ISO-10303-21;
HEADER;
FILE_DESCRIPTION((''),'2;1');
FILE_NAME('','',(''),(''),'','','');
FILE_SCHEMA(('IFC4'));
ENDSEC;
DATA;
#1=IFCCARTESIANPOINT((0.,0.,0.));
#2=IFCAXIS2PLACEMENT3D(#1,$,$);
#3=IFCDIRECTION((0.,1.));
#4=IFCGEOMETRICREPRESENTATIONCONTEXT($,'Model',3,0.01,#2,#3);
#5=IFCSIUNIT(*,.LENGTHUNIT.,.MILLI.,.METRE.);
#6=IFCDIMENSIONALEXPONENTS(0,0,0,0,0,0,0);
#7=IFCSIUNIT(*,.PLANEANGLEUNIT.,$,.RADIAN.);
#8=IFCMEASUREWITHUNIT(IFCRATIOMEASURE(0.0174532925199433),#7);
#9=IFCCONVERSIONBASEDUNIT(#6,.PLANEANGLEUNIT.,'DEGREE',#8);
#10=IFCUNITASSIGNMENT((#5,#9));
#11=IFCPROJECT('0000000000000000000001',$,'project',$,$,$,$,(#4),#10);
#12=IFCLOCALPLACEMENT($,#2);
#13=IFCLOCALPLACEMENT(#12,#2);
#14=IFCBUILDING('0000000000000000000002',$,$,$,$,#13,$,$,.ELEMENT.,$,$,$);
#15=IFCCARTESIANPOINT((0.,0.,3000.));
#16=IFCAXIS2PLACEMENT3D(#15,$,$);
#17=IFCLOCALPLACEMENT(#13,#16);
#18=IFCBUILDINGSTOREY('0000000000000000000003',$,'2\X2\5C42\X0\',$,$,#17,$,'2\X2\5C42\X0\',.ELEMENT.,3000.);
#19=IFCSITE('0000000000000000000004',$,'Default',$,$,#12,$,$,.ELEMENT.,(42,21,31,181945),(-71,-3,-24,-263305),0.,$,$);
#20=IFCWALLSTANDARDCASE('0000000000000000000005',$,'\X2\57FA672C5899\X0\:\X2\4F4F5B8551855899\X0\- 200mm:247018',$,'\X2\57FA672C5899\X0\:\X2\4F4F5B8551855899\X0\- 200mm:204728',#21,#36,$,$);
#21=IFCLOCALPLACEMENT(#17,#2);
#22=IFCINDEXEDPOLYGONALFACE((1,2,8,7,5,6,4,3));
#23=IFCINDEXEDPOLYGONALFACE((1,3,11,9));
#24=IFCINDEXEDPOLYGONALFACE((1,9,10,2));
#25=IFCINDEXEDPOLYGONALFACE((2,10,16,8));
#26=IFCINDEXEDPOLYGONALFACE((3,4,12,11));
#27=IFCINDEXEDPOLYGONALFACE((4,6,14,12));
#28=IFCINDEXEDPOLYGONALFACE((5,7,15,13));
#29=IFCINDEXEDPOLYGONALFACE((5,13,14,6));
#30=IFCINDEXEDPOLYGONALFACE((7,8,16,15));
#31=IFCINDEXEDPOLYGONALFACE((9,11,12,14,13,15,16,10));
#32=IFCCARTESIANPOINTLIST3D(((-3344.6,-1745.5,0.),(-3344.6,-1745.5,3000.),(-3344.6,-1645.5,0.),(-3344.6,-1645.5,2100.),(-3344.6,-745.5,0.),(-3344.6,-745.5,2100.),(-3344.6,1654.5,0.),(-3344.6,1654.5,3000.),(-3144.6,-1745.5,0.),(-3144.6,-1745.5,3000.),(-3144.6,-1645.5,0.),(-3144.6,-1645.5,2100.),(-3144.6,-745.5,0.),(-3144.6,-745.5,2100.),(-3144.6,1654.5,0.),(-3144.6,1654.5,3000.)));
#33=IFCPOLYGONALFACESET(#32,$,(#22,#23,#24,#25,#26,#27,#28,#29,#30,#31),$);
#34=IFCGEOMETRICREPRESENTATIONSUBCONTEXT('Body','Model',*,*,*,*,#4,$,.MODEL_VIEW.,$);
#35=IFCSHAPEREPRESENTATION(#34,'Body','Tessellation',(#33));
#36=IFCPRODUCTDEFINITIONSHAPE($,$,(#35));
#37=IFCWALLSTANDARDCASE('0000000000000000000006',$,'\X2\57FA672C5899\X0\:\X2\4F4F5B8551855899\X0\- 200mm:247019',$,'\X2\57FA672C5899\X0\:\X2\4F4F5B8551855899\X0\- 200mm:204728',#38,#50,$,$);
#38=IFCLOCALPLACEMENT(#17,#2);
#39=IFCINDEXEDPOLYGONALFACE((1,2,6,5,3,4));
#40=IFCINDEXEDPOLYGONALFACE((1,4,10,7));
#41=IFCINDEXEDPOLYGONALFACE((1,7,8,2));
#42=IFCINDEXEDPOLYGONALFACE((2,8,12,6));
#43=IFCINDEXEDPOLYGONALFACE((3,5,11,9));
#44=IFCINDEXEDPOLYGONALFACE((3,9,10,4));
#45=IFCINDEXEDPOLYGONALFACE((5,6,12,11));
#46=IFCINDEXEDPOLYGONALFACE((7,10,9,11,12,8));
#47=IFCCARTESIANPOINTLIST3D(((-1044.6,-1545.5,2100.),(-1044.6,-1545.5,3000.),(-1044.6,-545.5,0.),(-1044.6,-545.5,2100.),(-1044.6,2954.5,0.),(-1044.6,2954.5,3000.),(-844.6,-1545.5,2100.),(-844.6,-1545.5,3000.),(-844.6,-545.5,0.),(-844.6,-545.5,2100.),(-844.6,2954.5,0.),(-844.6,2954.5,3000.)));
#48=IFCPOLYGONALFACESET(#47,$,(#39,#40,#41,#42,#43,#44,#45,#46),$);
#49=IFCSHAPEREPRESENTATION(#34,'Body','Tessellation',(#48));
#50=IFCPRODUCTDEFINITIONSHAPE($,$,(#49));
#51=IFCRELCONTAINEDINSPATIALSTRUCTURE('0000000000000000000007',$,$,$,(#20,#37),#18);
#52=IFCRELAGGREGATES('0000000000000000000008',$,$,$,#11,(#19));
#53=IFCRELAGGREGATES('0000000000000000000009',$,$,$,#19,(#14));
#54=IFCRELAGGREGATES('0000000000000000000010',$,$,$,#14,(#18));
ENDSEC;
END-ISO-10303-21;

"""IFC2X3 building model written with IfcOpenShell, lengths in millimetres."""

from ifc_helpers import new_model, entity, si_unit, converted_unit, direction, frame, frame_2d, origin, place, context, subcontext, project, spatial, polyline, rectangle, extrude, clip, bounded_halfspace, element, save


model = new_model("IFC2X3")

# Units and contexts
model_context = context("Model", 3, precision=0.01, world=origin(), true_north=direction((0.0, 1.0)))
body_context = subcontext(model_context, "Body", "Model", "MODEL_VIEW")
ifc_project = project(units=[si_unit("LENGTHUNIT", "METRE", prefix="MILLI"), converted_unit("PLANEANGLEUNIT", "DEGREE", entity("IfcRatioMeasure", 0.0174532925199433), si_unit("PLANEANGLEUNIT", "RADIAN"), dimensions=[0, 0, 0, 0, 0, 0, 0])], contexts=[model_context])

# Site, building, storey
site_placement = place(None, origin())
site = spatial("IfcSite", under=ifc_project, at=site_placement, Name="Default", CompositionType="ELEMENT", RefLatitude=(42, 21, 31, 181945), RefLongitude=(-71, -3, -24, -263305), RefElevation=0.0)
building_placement = place(site_placement, origin())
building = spatial("IfcBuilding", under=site, at=building_placement, CompositionType="ELEMENT")
storey_placement = place(building_placement, frame((0.0, 0.0, 3000.0)))
storey = spatial("IfcBuildingStorey", under=building, at=storey_placement, Name="2层", LongName="2层", CompositionType="ELEMENT", Elevation=3000.0)

# Walls, openings
wall_1_placement = place(storey_placement, frame((-3244.6, -1745.5, 0.0), z_axis=(0.0, 0.0, 1.0), x_axis=(0.0, 1.0, 0.0)))
wall_1 = element("IfcWallStandardCase", 1, at=wall_1_placement, inside=storey, Name="基本墙:住宅内墙- 200mm:247018", ObjectType="基本墙:住宅内墙- 200mm:204728", context=body_context, shape_type="SweptSolid", body=[
    extrude(rectangle(XDim=3400.0, YDim=200.0, at=frame_2d((1700.0, 0.0), x_axis=(-1.0, 0.0))), origin(), (0.0, 0.0, 1.0), 3000.0),
])
opening_1_placement = place(wall_1_placement, frame((100.0, -100.0, 0.0)))
element("IfcOpeningElement", 2, at=opening_1_placement, cuts=wall_1, ObjectType="Opening", context=body_context, shape_type="SweptSolid", body=[
    extrude(rectangle(XDim=2100.0, YDim=900.0, at=frame_2d((1050.0, 450.0), x_axis=(1.0, 0.0))), frame((0.0, 0.0, 0.0), z_axis=(0.0, 1.0, 0.0), x_axis=(0.0, 0.0, 1.0)), (0.0, 0.0, 1.0), 200.0),
])
wall_2_placement = place(storey_placement, frame((-944.6, 2954.5, 0.0), z_axis=(0.0, 0.0, 1.0), x_axis=(0.0, -1.0, 0.0)))
wall_2 = element("IfcWallStandardCase", 3, at=wall_2_placement, inside=storey, Name="基本墙:住宅内墙- 200mm:247019", ObjectType="基本墙:住宅内墙- 200mm:204728", context=body_context, shape_type="Clipping", body=[
    clip(clip(extrude(rectangle(XDim=4500.0, YDim=200.0, at=frame_2d((2250.0, 0.0), x_axis=(-1.0, 0.0))), origin(), (0.0, 0.0, 1.0), 3000.0), bounded_halfspace(frame((4500.0, -100.0, 3000.0), z_axis=(-1.0, 0.0, 0.0), x_axis=(0.0, 0.0, -1.0)), True, frame((4500.0, -100.0, 3000.0), z_axis=(-1.0, 0.0, 0.0), x_axis=(0.0, 0.0, -1.0)), polyline([(0.0, 0.0), (0.0, -200.0), (900.0, -200.0), (900.0, 0.0), (0.0, 0.0)]))), bounded_halfspace(frame((0.0, -100.0, 0.0), z_axis=(1.0, 0.0, 0.0), x_axis=(0.0, 0.0, -1.0)), True, frame((0.0, -100.0, 0.0), z_axis=(1.0, 0.0, 0.0), x_axis=(0.0, 0.0, -1.0)), polyline([(0.0, 0.0), (0.0, 200.0), (-3000.0, 200.0), (-3000.0, 0.0), (0.0, 0.0)]))),
])
opening_2_placement = place(wall_2_placement, frame((3500.0, -100.0, 0.0)))
element("IfcOpeningElement", 4, at=opening_2_placement, cuts=wall_2, ObjectType="Opening", context=body_context, shape_type="SweptSolid", body=[
    extrude(rectangle(XDim=2100.0, YDim=1000.0, at=frame_2d((1050.0, 500.0), x_axis=(1.0, 0.0))), frame((0.0, 0.0, 0.0), z_axis=(0.0, 1.0, 0.0), x_axis=(0.0, 0.0, 1.0)), (0.0, 0.0, 1.0), 200.0),
])

save(model, "model.ifc")
